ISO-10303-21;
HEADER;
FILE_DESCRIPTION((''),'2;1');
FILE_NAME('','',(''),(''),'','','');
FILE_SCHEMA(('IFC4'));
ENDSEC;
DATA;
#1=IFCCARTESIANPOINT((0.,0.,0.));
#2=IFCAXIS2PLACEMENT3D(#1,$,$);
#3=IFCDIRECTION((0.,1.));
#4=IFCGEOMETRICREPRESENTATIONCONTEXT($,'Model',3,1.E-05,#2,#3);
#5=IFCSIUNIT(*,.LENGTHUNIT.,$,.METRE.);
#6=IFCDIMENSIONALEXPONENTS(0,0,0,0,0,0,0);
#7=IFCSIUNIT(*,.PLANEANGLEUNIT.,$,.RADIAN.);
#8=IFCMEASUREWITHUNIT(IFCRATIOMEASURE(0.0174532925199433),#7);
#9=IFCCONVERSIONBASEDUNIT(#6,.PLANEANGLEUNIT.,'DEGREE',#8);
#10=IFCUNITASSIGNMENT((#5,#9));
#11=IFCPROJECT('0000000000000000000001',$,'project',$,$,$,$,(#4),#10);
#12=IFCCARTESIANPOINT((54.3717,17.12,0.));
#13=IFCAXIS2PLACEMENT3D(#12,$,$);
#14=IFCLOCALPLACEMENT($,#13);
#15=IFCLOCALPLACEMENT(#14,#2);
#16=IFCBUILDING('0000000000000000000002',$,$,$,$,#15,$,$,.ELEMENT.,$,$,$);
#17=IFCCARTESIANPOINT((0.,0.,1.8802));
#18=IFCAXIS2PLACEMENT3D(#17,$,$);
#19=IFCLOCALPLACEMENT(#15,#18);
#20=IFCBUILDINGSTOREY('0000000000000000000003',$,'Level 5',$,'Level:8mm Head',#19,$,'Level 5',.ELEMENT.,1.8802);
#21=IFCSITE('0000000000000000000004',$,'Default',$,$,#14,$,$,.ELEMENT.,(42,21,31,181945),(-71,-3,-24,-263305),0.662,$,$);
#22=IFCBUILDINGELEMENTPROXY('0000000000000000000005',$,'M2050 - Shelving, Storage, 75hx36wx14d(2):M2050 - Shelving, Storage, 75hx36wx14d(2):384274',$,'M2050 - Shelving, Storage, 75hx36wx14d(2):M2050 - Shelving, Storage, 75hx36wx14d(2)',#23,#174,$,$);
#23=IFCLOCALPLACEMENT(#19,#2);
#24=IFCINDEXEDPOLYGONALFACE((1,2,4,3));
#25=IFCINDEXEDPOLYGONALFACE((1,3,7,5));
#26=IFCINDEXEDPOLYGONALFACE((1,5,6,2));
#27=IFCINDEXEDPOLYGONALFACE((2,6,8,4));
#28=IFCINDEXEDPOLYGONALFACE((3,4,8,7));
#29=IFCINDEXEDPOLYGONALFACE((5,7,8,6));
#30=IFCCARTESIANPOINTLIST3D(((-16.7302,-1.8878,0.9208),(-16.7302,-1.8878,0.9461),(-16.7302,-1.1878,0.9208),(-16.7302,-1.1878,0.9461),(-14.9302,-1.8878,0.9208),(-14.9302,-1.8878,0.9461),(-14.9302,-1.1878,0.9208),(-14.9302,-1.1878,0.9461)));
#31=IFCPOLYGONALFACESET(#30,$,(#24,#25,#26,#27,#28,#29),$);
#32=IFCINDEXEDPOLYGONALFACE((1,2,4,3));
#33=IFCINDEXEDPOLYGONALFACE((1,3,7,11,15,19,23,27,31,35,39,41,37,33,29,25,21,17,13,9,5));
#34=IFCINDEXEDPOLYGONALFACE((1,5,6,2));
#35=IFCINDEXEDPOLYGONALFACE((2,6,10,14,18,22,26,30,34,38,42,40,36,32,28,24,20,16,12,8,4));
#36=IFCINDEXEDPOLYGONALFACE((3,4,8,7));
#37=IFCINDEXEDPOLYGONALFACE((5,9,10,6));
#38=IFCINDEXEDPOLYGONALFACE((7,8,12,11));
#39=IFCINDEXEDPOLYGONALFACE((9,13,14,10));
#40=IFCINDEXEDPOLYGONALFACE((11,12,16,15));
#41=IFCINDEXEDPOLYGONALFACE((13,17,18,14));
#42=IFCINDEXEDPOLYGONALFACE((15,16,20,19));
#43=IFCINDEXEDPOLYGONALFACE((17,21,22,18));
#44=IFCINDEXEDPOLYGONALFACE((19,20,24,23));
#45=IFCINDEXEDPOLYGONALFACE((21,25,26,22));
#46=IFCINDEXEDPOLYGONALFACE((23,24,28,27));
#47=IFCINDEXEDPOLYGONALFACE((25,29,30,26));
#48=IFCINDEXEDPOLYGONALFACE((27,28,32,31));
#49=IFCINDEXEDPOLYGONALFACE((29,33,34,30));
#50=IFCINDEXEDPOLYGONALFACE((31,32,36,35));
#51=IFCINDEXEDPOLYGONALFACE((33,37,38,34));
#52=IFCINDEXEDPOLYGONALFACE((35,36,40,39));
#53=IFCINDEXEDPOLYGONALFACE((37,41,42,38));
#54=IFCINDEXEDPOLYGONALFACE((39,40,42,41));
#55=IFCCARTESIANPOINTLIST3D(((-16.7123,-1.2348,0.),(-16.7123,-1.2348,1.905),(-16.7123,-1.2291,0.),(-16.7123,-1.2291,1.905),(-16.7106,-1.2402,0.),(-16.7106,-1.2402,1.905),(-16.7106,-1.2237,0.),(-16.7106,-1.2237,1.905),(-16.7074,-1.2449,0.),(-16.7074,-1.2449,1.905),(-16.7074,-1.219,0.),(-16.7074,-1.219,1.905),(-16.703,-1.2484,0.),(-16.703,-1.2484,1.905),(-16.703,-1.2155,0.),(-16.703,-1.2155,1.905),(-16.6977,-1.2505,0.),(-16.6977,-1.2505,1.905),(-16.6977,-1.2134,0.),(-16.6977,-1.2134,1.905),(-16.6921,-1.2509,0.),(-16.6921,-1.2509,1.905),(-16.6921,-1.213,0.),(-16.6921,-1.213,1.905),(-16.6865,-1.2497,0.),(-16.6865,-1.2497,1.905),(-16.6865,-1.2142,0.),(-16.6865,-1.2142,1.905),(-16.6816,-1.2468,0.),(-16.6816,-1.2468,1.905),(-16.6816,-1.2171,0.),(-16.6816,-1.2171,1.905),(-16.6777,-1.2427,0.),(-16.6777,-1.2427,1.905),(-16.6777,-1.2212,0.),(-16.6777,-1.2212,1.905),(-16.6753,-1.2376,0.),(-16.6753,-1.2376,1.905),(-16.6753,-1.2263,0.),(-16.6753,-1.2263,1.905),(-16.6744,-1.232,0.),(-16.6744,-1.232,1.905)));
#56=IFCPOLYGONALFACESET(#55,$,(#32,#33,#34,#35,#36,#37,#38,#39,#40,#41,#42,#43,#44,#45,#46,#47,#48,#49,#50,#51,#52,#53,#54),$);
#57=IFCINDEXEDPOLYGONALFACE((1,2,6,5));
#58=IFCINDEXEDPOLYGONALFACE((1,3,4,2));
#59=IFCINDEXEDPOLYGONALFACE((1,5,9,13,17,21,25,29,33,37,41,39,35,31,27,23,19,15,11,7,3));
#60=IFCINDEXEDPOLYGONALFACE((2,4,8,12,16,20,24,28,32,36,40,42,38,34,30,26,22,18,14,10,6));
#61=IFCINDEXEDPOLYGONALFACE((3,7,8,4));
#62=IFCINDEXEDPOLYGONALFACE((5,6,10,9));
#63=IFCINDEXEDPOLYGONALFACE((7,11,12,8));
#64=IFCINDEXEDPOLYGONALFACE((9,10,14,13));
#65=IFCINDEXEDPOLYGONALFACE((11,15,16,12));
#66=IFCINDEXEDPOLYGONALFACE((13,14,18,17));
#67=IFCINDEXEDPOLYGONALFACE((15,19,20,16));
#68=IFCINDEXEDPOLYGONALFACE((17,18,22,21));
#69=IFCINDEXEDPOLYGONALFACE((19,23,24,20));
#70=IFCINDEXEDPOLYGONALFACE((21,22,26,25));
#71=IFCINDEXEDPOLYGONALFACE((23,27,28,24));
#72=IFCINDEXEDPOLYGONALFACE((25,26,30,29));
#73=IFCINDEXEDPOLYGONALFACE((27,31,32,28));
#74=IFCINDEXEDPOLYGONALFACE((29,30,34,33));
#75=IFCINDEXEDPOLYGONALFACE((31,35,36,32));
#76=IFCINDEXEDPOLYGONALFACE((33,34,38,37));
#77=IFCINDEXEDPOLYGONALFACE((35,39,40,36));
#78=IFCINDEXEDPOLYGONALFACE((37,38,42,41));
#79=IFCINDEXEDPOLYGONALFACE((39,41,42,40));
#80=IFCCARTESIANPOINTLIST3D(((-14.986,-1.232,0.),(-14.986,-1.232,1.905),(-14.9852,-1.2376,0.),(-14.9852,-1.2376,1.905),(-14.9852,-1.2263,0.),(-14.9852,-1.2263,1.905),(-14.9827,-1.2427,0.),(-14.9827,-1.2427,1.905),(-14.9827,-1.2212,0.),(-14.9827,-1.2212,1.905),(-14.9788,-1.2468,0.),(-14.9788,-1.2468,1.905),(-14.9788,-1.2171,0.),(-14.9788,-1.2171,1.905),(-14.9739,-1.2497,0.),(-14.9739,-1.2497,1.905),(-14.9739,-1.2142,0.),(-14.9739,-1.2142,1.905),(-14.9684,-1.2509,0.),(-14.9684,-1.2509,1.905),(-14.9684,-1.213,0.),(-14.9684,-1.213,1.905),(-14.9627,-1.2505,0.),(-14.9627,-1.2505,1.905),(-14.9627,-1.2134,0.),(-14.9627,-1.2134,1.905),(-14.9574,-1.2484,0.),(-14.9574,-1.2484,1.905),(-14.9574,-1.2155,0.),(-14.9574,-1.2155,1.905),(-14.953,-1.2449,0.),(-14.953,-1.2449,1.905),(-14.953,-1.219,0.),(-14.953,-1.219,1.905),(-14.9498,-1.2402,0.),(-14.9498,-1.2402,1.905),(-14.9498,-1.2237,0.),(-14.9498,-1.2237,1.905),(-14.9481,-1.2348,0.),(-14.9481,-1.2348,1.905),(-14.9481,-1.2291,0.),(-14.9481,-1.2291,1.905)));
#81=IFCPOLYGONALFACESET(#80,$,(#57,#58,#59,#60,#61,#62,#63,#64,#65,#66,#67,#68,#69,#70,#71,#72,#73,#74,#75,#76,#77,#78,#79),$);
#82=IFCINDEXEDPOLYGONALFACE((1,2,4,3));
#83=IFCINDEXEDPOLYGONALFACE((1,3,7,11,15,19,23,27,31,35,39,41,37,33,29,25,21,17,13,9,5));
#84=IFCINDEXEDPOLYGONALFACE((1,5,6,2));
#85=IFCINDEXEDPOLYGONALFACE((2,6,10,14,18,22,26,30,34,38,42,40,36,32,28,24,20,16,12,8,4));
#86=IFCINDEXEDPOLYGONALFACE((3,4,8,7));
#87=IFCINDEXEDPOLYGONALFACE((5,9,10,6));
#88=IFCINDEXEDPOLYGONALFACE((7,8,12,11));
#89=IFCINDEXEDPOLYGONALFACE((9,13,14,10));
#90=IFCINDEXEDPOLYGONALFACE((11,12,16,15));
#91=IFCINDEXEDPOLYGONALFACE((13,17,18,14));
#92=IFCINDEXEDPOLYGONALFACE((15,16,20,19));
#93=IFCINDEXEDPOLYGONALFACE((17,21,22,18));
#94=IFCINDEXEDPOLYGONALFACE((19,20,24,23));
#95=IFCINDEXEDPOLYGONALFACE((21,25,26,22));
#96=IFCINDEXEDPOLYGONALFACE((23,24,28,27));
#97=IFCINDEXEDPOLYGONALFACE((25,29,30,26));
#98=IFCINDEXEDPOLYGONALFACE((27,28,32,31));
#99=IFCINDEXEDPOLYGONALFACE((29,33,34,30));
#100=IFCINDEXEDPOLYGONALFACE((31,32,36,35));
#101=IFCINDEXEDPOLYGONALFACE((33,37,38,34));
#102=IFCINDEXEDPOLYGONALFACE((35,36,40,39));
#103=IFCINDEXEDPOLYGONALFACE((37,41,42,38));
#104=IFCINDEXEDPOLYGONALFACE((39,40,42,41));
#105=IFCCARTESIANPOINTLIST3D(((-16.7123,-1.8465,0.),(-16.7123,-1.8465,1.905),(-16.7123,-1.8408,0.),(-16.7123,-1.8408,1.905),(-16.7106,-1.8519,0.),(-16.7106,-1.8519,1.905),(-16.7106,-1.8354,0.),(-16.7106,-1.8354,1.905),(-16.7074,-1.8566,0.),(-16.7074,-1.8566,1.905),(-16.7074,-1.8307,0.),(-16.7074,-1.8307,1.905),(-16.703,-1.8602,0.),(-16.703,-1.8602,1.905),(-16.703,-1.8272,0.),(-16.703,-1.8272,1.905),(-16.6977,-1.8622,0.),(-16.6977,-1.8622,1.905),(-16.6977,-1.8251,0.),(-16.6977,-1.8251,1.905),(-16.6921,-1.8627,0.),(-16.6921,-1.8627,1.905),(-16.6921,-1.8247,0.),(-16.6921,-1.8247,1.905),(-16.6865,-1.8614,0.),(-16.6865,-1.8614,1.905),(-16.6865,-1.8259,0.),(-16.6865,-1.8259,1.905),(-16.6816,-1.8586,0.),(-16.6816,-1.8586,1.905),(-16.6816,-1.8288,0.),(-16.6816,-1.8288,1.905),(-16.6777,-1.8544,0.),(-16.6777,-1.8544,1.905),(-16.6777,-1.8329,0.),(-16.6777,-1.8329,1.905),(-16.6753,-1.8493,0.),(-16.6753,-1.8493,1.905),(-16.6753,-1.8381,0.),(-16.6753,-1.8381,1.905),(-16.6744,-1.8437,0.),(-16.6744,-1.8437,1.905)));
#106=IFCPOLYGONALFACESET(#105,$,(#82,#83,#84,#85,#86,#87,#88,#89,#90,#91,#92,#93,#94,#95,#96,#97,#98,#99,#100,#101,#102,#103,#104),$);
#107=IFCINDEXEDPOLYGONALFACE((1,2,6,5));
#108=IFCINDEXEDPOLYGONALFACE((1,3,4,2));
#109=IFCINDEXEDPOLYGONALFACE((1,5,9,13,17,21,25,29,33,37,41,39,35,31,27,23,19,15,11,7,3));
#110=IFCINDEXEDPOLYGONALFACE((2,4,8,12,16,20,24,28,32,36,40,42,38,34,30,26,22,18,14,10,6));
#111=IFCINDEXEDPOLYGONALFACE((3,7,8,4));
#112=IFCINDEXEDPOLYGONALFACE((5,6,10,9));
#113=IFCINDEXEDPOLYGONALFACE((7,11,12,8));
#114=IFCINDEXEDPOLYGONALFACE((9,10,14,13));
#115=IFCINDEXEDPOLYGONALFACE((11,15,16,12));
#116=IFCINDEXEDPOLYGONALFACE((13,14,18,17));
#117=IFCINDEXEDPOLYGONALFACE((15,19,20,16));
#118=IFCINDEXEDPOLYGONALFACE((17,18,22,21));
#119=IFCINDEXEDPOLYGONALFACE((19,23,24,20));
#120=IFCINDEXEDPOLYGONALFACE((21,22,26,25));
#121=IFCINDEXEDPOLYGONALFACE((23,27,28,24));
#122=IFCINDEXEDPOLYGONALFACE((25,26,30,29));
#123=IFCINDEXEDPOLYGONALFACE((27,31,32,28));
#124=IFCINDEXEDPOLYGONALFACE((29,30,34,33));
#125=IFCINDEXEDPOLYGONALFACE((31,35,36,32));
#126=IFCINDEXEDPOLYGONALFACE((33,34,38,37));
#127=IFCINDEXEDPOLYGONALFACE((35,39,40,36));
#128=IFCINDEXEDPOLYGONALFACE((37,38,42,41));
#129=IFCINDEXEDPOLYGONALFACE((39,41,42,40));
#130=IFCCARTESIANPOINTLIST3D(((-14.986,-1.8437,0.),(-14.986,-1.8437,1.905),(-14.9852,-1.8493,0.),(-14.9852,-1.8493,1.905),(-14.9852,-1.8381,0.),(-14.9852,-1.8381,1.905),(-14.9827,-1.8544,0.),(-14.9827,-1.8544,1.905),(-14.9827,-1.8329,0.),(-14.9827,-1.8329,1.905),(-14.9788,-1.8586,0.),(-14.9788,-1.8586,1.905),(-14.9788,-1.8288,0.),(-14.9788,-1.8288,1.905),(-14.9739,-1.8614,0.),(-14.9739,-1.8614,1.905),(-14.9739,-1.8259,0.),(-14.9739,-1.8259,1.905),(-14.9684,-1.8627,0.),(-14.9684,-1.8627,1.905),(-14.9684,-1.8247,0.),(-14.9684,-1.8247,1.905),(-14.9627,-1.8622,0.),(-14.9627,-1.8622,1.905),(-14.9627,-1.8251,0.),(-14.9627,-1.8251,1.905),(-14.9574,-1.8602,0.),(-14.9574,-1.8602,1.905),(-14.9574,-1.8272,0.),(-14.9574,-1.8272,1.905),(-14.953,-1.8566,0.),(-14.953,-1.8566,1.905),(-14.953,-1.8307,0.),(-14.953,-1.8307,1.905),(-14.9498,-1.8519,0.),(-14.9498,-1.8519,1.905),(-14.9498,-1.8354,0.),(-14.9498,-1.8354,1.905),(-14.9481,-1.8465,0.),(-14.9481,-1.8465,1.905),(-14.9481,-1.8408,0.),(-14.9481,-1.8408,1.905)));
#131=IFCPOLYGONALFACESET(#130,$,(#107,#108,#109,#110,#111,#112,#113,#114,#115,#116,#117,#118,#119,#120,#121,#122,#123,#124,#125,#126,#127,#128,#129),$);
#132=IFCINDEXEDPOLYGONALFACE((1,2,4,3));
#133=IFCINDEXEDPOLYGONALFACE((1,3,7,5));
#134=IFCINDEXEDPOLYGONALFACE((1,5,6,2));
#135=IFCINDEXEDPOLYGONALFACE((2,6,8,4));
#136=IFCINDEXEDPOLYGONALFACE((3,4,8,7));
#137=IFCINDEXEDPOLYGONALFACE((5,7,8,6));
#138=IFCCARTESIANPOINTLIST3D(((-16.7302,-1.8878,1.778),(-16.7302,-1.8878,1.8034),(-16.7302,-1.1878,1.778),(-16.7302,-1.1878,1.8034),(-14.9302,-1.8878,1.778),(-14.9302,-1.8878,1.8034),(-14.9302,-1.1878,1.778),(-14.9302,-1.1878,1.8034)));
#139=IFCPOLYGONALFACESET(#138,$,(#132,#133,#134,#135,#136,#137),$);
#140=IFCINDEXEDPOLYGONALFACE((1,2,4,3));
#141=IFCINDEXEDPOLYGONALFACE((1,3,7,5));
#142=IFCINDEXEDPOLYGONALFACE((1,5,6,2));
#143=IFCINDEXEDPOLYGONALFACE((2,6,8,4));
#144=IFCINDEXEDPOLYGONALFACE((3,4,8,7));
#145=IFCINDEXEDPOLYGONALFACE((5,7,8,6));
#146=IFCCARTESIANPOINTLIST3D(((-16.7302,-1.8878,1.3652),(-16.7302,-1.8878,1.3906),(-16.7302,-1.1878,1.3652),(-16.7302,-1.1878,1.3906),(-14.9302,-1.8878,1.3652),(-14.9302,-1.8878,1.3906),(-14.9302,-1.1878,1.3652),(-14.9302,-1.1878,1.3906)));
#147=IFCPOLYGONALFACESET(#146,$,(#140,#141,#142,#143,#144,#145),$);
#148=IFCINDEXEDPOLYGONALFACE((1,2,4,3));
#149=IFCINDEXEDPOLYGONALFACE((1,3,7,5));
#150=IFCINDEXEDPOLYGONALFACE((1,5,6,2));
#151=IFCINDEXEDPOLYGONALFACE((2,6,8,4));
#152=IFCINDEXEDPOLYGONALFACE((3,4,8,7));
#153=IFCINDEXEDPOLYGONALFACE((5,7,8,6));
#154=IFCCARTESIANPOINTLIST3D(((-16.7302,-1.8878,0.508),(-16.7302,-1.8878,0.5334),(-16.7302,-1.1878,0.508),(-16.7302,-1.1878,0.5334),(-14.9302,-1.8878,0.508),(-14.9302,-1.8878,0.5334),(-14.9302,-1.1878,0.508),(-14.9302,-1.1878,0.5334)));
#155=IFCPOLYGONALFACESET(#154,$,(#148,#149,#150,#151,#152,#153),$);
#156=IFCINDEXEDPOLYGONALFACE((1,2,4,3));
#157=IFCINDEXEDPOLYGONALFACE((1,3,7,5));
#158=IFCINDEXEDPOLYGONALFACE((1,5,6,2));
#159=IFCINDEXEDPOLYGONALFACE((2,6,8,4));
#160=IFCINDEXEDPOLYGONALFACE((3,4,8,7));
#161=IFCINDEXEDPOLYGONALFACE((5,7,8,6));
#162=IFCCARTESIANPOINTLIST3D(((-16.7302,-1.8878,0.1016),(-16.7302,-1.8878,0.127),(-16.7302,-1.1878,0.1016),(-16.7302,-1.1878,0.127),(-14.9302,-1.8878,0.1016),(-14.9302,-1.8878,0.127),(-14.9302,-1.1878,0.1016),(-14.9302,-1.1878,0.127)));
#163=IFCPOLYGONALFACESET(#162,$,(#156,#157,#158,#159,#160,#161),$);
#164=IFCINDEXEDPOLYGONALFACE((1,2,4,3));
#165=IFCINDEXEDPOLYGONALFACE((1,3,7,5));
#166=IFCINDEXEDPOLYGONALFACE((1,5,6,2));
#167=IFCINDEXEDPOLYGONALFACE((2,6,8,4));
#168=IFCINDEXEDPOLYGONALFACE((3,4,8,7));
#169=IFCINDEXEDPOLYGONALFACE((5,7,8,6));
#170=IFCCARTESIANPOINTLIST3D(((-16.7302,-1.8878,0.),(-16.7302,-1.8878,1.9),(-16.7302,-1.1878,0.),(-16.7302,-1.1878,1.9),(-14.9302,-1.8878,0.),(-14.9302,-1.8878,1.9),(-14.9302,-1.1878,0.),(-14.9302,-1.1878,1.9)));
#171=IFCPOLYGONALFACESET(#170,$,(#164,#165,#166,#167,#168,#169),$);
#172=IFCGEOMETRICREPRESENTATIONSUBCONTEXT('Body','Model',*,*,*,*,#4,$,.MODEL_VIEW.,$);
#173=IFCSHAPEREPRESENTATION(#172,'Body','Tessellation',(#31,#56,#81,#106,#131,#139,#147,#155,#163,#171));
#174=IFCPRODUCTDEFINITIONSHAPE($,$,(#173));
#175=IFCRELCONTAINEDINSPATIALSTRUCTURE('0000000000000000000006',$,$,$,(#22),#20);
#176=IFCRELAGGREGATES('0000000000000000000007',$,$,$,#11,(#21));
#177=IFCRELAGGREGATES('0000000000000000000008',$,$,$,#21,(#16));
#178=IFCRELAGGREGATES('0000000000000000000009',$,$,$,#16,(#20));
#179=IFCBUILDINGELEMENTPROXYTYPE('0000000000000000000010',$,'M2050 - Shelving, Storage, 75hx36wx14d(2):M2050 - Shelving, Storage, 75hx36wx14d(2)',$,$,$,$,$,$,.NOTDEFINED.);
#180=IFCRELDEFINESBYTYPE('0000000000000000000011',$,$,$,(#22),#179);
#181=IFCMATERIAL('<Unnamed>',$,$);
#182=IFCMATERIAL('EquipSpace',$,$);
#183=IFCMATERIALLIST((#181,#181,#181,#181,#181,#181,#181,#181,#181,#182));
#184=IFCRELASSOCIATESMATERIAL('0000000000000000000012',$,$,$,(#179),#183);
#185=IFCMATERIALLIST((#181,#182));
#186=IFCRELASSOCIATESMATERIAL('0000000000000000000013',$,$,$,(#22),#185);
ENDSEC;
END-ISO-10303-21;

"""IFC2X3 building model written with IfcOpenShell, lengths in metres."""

from ifc_helpers import new_model, entity, si_unit, converted_unit, direction, frame, frame_2d, origin, origin_2d_with_axis, place, context, subcontext, project, spatial, rectangle, circle, extrude, source, transform, mapped, material, material_list, type_object, type_shapes, element, save


model = new_model("IFC2X3")

# Units and contexts
model_context = context("Model", 3, precision=1e-05, world=origin(), true_north=direction((0.0, 1.0)))
body_context = subcontext(model_context, "Body", "Model", "MODEL_VIEW")
ifc_project = project(units=[si_unit("LENGTHUNIT", "METRE"), converted_unit("PLANEANGLEUNIT", "DEGREE", entity("IfcRatioMeasure", 0.0174532925199433), si_unit("PLANEANGLEUNIT", "RADIAN"), dimensions=[0, 0, 0, 0, 0, 0, 0])], contexts=[model_context])

# Site, building, storey
site_placement = place(None, frame((54.3717, 17.12, 0.0)))
site = spatial("IfcSite", under=ifc_project, at=site_placement, Name="Default", CompositionType="ELEMENT", RefLatitude=(42, 21, 31, 181945), RefLongitude=(-71, -3, -24, -263305), RefElevation=0.662)
building_placement = place(site_placement, origin())
building = spatial("IfcBuilding", under=site, at=building_placement, CompositionType="ELEMENT")
storey_placement = place(building_placement, frame((0.0, 0.0, 1.8802)))
storey = spatial("IfcBuildingStorey", under=building, at=storey_placement, Name="Level 5", ObjectType="Level:8mm Head", LongName="Level 5", CompositionType="ELEMENT", Elevation=1.8802)

# Building element proxy
ifc_material_1 = material(Name="<Unnamed>")
ifc_material_2 = material(Name="EquipSpace")
ifc_material_list_1 = material_list([ifc_material_1, ifc_material_1, ifc_material_1, ifc_material_1, ifc_material_1, ifc_material_1, ifc_material_1, ifc_material_1, ifc_material_1, ifc_material_2])
building_element_proxy_type = type_object("IfcBuildingElementProxyType", Name="M2050 - Shelving, Storage, 75hx36wx14d(2):M2050 - Shelving, Storage, 75hx36wx14d(2)", PredefinedType="NOTDEFINED", material=ifc_material_list_1)
shared_shape = source(origin(), body_context, "Body", "SweptSolid", [
    extrude(rectangle(XDim=1.8, YDim=0.7, at=origin_2d_with_axis()), frame((0.0, 0.0, 0.9207), z_axis=(0.0, 0.0, 1.0), x_axis=(-1.0, 0.0, 0.0)), (0.0, 0.0, 1.0), 0.0254),
    extrude(circle(Radius=0.0191, at=origin_2d_with_axis()), frame((0.8633, -0.3059, 0.0), z_axis=(0.0, 0.0, 1.0), x_axis=(-1.0, 0.0, 0.0)), (0.0, 0.0, 1.0), 1.905),
    extrude(circle(Radius=0.0191, at=origin_2d_with_axis()), frame((-0.8633, -0.3059, 0.0)), (0.0, 0.0, 1.0), 1.905),
    extrude(circle(Radius=0.0191, at=origin_2d_with_axis()), frame((0.8633, 0.3059, 0.0), z_axis=(0.0, 0.0, 1.0), x_axis=(-1.0, 0.0, 0.0)), (0.0, 0.0, 1.0), 1.905),
    extrude(circle(Radius=0.0191, at=origin_2d_with_axis()), frame((-0.8633, 0.3059, 0.0)), (0.0, 0.0, 1.0), 1.905),
    extrude(rectangle(XDim=1.8, YDim=0.7, at=origin_2d_with_axis()), frame((0.0, 0.0, 1.778), z_axis=(0.0, 0.0, 1.0), x_axis=(-1.0, 0.0, 0.0)), (0.0, 0.0, 1.0), 0.0254),
    extrude(rectangle(XDim=1.8, YDim=0.7, at=origin_2d_with_axis()), frame((0.0, 0.0, 1.3653), z_axis=(0.0, 0.0, 1.0), x_axis=(-1.0, 0.0, 0.0)), (0.0, 0.0, 1.0), 0.0254),
    extrude(rectangle(XDim=1.8, YDim=0.7, at=origin_2d_with_axis()), frame((0.0, 0.0, 0.508), z_axis=(0.0, 0.0, 1.0), x_axis=(-1.0, 0.0, 0.0)), (0.0, 0.0, 1.0), 0.0254),
    extrude(rectangle(XDim=1.8, YDim=0.7, at=origin_2d_with_axis()), frame((0.0, 0.0, 0.1016), z_axis=(0.0, 0.0, 1.0), x_axis=(-1.0, 0.0, 0.0)), (0.0, 0.0, 1.0), 0.0254),
    extrude(rectangle(XDim=0.7, YDim=1.8, at=frame_2d((0.0, 0.18), x_axis=(1.0, 0.0))), frame((-0.18, 0.0, 0.0), z_axis=(0.0, 0.0, 1.0), x_axis=(0.0, -1.0, 0.0)), (0.0, 0.0, 1.0), 1.9),
])
type_shapes(building_element_proxy_type, [shared_shape])
ifc_material_list_2 = material_list([ifc_material_1, ifc_material_2])
proxy_1_placement = place(storey_placement, frame((-15.8302, -1.5378, 0.0), z_axis=(0.0, 0.0, 1.0), x_axis=(-1.0, 0.0, 0.0)))
element("IfcBuildingElementProxy", 1, at=proxy_1_placement, inside=storey, type_object=building_element_proxy_type, material=ifc_material_list_2, Name="M2050 - Shelving, Storage, 75hx36wx14d(2):M2050 - Shelving, Storage, 75hx36wx14d(2):384274", ObjectType="M2050 - Shelving, Storage, 75hx36wx14d(2):M2050 - Shelving, Storage, 75hx36wx14d(2)", context=body_context, shape_type="MappedRepresentation", body=[
    mapped(shared_shape, transform((0.0, 0.0, 0.0), scale=1.0)),
])

save(model, "model.ifc")
